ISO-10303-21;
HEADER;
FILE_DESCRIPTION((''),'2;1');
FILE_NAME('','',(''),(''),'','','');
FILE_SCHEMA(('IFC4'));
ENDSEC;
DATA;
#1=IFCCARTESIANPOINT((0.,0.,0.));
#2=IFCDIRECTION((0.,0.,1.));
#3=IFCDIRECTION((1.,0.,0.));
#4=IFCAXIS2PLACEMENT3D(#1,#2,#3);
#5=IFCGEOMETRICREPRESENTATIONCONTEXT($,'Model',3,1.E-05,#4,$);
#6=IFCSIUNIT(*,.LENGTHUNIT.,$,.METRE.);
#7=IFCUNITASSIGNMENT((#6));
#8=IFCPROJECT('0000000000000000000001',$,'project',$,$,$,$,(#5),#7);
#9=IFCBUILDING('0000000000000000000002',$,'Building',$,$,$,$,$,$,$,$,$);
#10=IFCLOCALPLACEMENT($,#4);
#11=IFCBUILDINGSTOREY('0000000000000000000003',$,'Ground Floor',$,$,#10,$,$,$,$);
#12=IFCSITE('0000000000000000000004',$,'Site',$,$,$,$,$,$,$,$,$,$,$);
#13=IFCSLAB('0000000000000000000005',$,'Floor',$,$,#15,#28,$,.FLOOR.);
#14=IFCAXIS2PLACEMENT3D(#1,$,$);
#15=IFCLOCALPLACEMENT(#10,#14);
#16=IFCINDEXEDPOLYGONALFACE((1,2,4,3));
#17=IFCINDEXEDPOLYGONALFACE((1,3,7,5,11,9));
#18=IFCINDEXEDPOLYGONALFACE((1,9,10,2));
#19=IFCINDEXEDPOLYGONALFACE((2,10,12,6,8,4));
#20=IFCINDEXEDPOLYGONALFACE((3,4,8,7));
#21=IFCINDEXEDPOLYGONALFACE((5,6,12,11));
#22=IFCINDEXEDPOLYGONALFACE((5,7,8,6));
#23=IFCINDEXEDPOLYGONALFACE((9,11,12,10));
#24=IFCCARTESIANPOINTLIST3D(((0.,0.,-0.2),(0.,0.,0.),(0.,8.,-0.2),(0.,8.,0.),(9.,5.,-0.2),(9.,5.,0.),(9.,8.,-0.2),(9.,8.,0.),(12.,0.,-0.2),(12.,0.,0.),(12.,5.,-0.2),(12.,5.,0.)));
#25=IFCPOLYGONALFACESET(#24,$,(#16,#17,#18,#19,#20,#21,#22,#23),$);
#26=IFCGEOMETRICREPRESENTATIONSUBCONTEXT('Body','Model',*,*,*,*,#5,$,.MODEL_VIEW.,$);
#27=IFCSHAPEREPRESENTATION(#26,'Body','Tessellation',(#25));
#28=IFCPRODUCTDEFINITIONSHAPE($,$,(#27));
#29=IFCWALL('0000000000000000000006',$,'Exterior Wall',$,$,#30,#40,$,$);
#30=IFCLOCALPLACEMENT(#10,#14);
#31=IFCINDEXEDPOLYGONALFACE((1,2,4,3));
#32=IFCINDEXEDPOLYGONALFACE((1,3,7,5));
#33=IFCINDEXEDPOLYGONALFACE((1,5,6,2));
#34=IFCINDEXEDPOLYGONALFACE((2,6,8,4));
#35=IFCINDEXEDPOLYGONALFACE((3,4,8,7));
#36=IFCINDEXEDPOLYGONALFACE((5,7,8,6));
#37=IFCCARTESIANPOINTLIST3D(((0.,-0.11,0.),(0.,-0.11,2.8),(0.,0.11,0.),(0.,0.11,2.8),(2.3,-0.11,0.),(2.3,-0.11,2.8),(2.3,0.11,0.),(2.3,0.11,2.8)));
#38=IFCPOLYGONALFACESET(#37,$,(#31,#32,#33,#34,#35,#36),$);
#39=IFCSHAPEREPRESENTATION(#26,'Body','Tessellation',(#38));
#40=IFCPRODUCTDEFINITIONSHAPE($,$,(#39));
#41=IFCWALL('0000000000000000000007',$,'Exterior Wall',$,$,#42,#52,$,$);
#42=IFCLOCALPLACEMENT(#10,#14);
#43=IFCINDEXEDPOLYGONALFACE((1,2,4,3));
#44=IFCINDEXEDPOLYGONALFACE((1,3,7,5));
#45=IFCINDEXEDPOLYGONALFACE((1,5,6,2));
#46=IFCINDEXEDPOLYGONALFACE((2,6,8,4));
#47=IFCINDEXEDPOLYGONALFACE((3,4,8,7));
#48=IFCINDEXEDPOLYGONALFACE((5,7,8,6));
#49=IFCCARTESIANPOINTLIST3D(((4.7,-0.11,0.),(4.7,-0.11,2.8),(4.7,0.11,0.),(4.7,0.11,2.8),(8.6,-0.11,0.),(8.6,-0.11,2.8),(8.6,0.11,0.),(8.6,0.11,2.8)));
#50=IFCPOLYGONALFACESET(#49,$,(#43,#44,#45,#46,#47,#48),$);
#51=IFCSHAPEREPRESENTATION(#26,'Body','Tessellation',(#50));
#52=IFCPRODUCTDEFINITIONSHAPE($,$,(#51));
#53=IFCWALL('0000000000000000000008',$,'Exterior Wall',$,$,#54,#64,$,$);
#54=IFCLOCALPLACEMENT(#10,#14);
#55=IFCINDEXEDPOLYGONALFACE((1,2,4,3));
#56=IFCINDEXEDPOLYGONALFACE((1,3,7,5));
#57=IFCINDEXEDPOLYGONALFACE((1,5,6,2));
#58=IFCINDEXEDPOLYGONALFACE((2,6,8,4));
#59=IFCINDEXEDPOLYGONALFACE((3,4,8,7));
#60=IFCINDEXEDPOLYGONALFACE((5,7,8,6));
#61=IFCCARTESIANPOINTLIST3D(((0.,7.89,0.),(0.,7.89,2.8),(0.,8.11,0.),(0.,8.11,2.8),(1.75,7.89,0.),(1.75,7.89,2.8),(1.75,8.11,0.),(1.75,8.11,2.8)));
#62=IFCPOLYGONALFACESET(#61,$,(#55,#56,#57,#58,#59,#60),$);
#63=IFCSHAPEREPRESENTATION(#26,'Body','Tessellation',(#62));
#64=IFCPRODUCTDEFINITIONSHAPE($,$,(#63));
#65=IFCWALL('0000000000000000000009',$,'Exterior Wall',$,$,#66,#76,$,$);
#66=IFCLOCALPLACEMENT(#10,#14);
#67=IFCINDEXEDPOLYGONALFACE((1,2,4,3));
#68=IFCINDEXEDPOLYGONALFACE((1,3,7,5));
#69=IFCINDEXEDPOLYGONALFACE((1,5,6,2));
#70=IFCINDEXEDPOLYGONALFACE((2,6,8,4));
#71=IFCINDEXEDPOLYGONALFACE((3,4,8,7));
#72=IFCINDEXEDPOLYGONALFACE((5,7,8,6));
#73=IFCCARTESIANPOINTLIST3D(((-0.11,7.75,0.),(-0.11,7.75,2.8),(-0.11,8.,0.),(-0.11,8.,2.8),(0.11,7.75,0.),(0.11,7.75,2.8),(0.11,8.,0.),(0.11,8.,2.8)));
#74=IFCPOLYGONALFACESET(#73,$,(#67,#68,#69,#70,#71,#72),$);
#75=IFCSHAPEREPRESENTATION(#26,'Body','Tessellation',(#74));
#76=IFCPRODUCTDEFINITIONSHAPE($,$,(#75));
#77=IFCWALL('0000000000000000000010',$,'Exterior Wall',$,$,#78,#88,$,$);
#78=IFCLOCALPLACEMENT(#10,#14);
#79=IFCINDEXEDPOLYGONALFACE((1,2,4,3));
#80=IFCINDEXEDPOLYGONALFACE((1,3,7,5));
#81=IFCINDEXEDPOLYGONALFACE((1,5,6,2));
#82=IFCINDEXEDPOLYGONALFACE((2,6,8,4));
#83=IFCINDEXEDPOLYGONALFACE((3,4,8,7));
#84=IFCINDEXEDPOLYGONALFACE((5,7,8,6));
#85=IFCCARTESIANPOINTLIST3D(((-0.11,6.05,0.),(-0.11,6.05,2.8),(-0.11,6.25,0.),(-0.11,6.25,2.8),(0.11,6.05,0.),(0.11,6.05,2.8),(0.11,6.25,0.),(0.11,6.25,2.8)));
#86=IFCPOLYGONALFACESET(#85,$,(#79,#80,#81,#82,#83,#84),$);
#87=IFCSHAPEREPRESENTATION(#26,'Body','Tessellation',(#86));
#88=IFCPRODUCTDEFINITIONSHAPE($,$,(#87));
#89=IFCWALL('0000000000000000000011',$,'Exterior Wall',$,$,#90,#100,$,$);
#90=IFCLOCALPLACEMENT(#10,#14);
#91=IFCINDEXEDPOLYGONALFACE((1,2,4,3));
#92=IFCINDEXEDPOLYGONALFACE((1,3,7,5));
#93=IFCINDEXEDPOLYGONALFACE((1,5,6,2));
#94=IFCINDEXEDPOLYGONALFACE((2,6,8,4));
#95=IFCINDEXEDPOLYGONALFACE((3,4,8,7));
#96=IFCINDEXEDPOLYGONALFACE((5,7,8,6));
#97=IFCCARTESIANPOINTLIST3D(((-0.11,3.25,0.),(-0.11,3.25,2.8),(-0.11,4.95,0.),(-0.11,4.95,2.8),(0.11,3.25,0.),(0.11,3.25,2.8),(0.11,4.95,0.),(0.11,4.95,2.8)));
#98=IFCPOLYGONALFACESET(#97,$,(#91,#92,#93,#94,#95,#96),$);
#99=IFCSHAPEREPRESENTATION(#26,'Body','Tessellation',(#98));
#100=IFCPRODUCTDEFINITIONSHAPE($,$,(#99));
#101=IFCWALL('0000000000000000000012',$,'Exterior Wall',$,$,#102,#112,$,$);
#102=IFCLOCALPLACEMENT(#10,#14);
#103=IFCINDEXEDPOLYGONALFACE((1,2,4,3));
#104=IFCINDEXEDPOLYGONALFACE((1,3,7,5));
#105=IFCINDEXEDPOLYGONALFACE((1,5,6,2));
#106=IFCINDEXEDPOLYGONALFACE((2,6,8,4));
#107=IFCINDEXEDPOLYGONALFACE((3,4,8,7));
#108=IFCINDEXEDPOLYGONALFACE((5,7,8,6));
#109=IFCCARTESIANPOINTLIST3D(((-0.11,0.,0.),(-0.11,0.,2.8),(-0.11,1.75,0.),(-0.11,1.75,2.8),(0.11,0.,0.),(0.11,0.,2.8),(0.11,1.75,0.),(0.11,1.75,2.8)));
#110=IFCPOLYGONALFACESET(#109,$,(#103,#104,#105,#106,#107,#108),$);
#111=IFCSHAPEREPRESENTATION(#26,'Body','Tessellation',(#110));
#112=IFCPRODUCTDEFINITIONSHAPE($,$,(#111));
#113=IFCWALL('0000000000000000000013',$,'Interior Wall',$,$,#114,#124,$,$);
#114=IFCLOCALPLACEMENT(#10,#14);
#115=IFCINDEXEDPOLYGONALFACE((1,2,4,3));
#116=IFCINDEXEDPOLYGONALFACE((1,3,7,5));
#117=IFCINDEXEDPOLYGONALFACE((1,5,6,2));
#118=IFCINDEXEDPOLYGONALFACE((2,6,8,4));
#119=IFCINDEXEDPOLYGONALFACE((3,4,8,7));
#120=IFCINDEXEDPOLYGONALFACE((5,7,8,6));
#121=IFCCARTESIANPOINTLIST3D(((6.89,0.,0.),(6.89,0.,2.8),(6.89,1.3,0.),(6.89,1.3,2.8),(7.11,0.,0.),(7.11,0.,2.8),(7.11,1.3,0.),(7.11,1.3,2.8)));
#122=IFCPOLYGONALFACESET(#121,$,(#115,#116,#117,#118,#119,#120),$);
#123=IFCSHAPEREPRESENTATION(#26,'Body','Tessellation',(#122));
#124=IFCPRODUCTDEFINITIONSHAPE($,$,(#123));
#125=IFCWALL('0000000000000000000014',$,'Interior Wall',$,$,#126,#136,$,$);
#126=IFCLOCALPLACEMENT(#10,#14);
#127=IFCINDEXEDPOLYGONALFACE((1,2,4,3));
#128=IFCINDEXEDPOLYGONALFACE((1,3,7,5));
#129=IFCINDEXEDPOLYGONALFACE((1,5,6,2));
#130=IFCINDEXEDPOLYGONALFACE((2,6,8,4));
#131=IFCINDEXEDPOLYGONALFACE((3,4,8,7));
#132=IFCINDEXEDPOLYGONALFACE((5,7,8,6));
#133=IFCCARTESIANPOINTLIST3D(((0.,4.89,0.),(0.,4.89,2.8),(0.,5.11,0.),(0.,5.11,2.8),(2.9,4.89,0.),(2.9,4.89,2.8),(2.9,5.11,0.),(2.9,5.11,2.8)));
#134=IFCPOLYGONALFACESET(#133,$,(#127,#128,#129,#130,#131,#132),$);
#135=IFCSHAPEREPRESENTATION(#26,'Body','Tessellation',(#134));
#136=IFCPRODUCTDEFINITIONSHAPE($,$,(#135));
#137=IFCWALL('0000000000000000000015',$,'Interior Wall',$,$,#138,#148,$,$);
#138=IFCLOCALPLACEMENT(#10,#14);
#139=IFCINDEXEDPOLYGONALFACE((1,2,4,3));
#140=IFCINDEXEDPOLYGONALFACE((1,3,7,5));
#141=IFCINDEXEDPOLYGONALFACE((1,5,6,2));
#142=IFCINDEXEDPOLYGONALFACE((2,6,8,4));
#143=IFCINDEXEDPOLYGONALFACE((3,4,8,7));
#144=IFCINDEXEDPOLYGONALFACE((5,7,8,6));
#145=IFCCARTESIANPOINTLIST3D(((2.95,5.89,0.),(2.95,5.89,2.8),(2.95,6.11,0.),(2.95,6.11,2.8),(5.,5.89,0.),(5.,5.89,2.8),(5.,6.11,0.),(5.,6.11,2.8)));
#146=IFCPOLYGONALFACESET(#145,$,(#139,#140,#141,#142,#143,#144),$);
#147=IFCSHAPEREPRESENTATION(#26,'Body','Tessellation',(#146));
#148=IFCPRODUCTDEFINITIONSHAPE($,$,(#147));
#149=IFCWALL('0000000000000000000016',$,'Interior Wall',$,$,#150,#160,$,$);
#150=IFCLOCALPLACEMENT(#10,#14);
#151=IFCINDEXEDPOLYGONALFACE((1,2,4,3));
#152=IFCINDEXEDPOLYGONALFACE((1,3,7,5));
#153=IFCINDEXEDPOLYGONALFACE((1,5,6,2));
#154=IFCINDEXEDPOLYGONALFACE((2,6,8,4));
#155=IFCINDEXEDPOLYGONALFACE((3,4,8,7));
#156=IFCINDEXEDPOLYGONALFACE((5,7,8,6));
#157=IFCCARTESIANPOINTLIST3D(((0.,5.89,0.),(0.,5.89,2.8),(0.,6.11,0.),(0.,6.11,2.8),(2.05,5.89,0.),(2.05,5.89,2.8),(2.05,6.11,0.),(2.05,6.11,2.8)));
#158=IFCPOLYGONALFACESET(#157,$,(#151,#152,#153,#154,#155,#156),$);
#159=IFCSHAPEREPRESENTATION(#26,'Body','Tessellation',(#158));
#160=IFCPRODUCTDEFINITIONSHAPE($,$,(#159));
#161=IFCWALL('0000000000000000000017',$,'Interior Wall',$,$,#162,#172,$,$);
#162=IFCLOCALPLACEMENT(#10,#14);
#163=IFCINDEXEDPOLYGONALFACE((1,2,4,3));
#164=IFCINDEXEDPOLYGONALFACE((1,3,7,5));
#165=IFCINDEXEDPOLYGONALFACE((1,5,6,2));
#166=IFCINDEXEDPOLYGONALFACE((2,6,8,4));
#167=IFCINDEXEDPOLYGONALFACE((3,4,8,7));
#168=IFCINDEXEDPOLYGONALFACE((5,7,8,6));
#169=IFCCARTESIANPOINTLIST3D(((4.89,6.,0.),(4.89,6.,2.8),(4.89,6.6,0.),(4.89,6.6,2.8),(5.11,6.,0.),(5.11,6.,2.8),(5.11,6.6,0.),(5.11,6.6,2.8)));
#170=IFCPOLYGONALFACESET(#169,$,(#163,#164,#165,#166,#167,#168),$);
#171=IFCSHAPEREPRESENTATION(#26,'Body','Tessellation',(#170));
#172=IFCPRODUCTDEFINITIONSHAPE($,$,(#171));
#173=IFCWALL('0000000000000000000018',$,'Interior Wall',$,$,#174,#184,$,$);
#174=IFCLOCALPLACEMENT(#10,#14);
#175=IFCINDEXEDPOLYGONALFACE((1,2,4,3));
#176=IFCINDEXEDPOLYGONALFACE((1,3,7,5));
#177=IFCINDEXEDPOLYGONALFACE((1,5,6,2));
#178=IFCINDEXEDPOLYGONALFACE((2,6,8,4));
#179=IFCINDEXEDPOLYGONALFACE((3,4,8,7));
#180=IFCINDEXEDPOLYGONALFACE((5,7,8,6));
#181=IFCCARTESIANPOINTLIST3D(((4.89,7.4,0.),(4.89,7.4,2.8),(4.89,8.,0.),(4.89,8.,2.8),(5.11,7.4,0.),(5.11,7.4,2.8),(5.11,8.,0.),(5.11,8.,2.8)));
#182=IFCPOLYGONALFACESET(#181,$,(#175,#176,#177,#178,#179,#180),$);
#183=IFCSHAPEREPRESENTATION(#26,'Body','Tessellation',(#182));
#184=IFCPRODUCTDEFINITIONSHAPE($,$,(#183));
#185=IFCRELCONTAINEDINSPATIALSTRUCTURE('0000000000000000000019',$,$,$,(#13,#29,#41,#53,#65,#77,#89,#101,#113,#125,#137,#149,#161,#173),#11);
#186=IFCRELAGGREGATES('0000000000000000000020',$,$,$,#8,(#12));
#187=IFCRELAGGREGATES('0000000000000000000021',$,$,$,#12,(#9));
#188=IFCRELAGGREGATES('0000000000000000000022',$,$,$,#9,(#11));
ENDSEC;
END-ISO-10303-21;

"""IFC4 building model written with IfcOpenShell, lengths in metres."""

from ifc_helpers import new_model, si_unit, frame, origin_with_axes, place, context, subcontext, project, spatial, indexed_curve, outline, extrude, element, save


model = new_model("IFC4")

# Units and contexts
model_context = context("Model", 3, precision=1e-05, world=origin_with_axes())
body_context = subcontext(model_context, "Body", "Model", "MODEL_VIEW")
ifc_project = project(units=[si_unit("LENGTHUNIT", "METRE")], contexts=[model_context])

# Site, building, storey
site = spatial("IfcSite", under=ifc_project, Name="Site")
building = spatial("IfcBuilding", under=site, Name="Building")
storey_placement = place(None, origin_with_axes())
storey = spatial("IfcBuildingStorey", under=building, at=storey_placement, Name="Ground Floor")

# Slab
slab_placement = place(storey_placement, frame((0.0, 0.0, -0.2), z_axis=(0.0, 0.0, 1.0), x_axis=(1.0, 0.0, 0.0)))
element("IfcSlab", 1, at=slab_placement, inside=storey, Name="Floor", PredefinedType="FLOOR", context=body_context, shape_type="SweptSolid", body=[
    extrude(outline(indexed_curve([(0.0, 0.0), (12.0, 0.0), (12.0, 5.0), (9.0, 5.0), (9.0, 8.0), (0.0, 8.0)])), None, (0.0, 0.0, 1.0), 0.2),
])

# Walls
wall_1_placement = place(storey_placement, origin_with_axes())
element("IfcWall", 2, at=wall_1_placement, inside=storey, Name="Exterior Wall", context=body_context, shape_type="SweptSolid", body=[
    extrude(outline(indexed_curve([(0.0, 0.0), (0.0, 0.22), (2.3, 0.22), (2.3, 0.0), (0.0, 0.0)], self_intersect=False)), frame((0.0, -0.11, 0.0), z_axis=(0.0, 0.0, 1.0), x_axis=(1.0, 0.0, 0.0)), (0.0, 0.0, 1.0), 2.8),
])
wall_2_placement = place(storey_placement, frame((4.7, 0.0, 0.0), z_axis=(0.0, 0.0, 1.0), x_axis=(1.0, 0.0, 0.0)))
element("IfcWall", 3, at=wall_2_placement, inside=storey, Name="Exterior Wall", context=body_context, shape_type="SweptSolid", body=[
    extrude(outline(indexed_curve([(0.0, 0.0), (0.0, 0.22), (3.9, 0.22), (3.9, 0.0), (0.0, 0.0)], self_intersect=False)), frame((0.0, -0.11, 0.0), z_axis=(0.0, 0.0, 1.0), x_axis=(1.0, 0.0, 0.0)), (0.0, 0.0, 1.0), 2.8),
])
wall_3_placement = place(storey_placement, frame((1.75, 8.0, 0.0), z_axis=(0.0, 0.0, 1.0), x_axis=(-1.0, 0.0, 0.0)))
element("IfcWall", 4, at=wall_3_placement, inside=storey, Name="Exterior Wall", context=body_context, shape_type="SweptSolid", body=[
    extrude(outline(indexed_curve([(0.0, 0.0), (0.0, 0.22), (1.75, 0.22), (1.75, 0.0), (0.0, 0.0)], self_intersect=False)), frame((0.0, -0.11, 0.0), z_axis=(0.0, 0.0, 1.0), x_axis=(1.0, 0.0, 0.0)), (0.0, 0.0, 1.0), 2.8),
])
wall_4_placement = place(storey_placement, frame((0.0, 8.0, 0.0), z_axis=(0.0, 0.0, 1.0), x_axis=(0.0, -1.0, 0.0)))
element("IfcWall", 5, at=wall_4_placement, inside=storey, Name="Exterior Wall", context=body_context, shape_type="SweptSolid", body=[
    extrude(outline(indexed_curve([(0.0, 0.0), (0.0, 0.22), (0.25, 0.22), (0.25, 0.0), (0.0, 0.0)], self_intersect=False)), frame((0.0, -0.11, 0.0), z_axis=(0.0, 0.0, 1.0), x_axis=(1.0, 0.0, 0.0)), (0.0, 0.0, 1.0), 2.8),
])
wall_5_placement = place(storey_placement, frame((0.0, 6.25, 0.0), z_axis=(0.0, 0.0, 1.0), x_axis=(0.0, -1.0, 0.0)))
element("IfcWall", 6, at=wall_5_placement, inside=storey, Name="Exterior Wall", context=body_context, shape_type="SweptSolid", body=[
    extrude(outline(indexed_curve([(0.0, 0.0), (0.0, 0.22), (0.2, 0.22), (0.2, 0.0), (0.0, 0.0)], self_intersect=False)), frame((0.0, -0.11, 0.0), z_axis=(0.0, 0.0, 1.0), x_axis=(1.0, 0.0, 0.0)), (0.0, 0.0, 1.0), 2.8),
])
wall_6_placement = place(storey_placement, frame((0.0, 4.95, 0.0), z_axis=(0.0, 0.0, 1.0), x_axis=(0.0, -1.0, 0.0)))
element("IfcWall", 7, at=wall_6_placement, inside=storey, Name="Exterior Wall", context=body_context, shape_type="SweptSolid", body=[
    extrude(outline(indexed_curve([(0.0, 0.0), (0.0, 0.22), (1.7, 0.22), (1.7, 0.0), (0.0, 0.0)], self_intersect=False)), frame((0.0, -0.11, 0.0), z_axis=(0.0, 0.0, 1.0), x_axis=(1.0, 0.0, 0.0)), (0.0, 0.0, 1.0), 2.8),
])
wall_7_placement = place(storey_placement, frame((0.0, 1.75, 0.0), z_axis=(0.0, 0.0, 1.0), x_axis=(0.0, -1.0, 0.0)))
element("IfcWall", 8, at=wall_7_placement, inside=storey, Name="Exterior Wall", context=body_context, shape_type="SweptSolid", body=[
    extrude(outline(indexed_curve([(0.0, 0.0), (0.0, 0.22), (1.75, 0.22), (1.75, 0.0), (0.0, 0.0)], self_intersect=False)), frame((0.0, -0.11, 0.0), z_axis=(0.0, 0.0, 1.0), x_axis=(1.0, 0.0, 0.0)), (0.0, 0.0, 1.0), 2.8),
])
wall_8_placement = place(storey_placement, frame((7.0, 0.0, 0.0), z_axis=(0.0, 0.0, 1.0), x_axis=(0.0, 1.0, 0.0)))
element("IfcWall", 9, at=wall_8_placement, inside=storey, Name="Interior Wall", context=body_context, shape_type="SweptSolid", body=[
    extrude(outline(indexed_curve([(0.0, 0.0), (0.0, 0.22), (1.3, 0.22), (1.3, 0.0), (0.0, 0.0)], self_intersect=False)), frame((0.0, -0.11, 0.0), z_axis=(0.0, 0.0, 1.0), x_axis=(1.0, 0.0, 0.0)), (0.0, 0.0, 1.0), 2.8),
])
wall_9_placement = place(storey_placement, frame((2.9, 5.0, 0.0), z_axis=(0.0, 0.0, 1.0), x_axis=(-1.0, 0.0, 0.0)))
element("IfcWall", 10, at=wall_9_placement, inside=storey, Name="Interior Wall", context=body_context, shape_type="SweptSolid", body=[
    extrude(outline(indexed_curve([(0.0, 0.0), (0.0, 0.22), (2.9, 0.22), (2.9, 0.0), (0.0, 0.0)], self_intersect=False)), frame((0.0, -0.11, 0.0), z_axis=(0.0, 0.0, 1.0), x_axis=(1.0, 0.0, 0.0)), (0.0, 0.0, 1.0), 2.8),
])
for number, where, z_axis, x_axis, name in (
    (11, (5.0, 6.0, 0.0), (0.0, 0.0, 1.0), (-1.0, 0.0, 0.0), "Interior Wall"),
    (12, (2.05, 6.0, 0.0), (0.0, 0.0, 1.0), (-1.0, 0.0, 0.0), "Interior Wall"),
):
    element("IfcWall", number, at=place(storey_placement, frame(where, z_axis=z_axis, x_axis=x_axis)), inside=storey, Name=name, context=body_context, shape_type="SweptSolid", body=[
        extrude(outline(indexed_curve([(0.0, 0.0), (0.0, 0.22), (2.05, 0.22), (2.05, 0.0), (0.0, 0.0)], self_intersect=False)), frame((0.0, -0.11, 0.0), z_axis=(0.0, 0.0, 1.0), x_axis=(1.0, 0.0, 0.0)), (0.0, 0.0, 1.0), 2.8),
    ])
for number, where, z_axis, x_axis, name in (
    (13, (5.0, 6.0, 0.0), (0.0, 0.0, 1.0), (0.0, 1.0, 0.0), "Interior Wall"),
    (14, (5.0, 7.4, 0.0), (0.0, 0.0, 1.0), (0.0, 1.0, 0.0), "Interior Wall"),
):
    element("IfcWall", number, at=place(storey_placement, frame(where, z_axis=z_axis, x_axis=x_axis)), inside=storey, Name=name, context=body_context, shape_type="SweptSolid", body=[
        extrude(outline(indexed_curve([(0.0, 0.0), (0.0, 0.22), (0.6, 0.22), (0.6, 0.0), (0.0, 0.0)], self_intersect=False)), frame((0.0, -0.11, 0.0), z_axis=(0.0, 0.0, 1.0), x_axis=(1.0, 0.0, 0.0)), (0.0, 0.0, 1.0), 2.8),
    ])

save(model, "model.ifc")
